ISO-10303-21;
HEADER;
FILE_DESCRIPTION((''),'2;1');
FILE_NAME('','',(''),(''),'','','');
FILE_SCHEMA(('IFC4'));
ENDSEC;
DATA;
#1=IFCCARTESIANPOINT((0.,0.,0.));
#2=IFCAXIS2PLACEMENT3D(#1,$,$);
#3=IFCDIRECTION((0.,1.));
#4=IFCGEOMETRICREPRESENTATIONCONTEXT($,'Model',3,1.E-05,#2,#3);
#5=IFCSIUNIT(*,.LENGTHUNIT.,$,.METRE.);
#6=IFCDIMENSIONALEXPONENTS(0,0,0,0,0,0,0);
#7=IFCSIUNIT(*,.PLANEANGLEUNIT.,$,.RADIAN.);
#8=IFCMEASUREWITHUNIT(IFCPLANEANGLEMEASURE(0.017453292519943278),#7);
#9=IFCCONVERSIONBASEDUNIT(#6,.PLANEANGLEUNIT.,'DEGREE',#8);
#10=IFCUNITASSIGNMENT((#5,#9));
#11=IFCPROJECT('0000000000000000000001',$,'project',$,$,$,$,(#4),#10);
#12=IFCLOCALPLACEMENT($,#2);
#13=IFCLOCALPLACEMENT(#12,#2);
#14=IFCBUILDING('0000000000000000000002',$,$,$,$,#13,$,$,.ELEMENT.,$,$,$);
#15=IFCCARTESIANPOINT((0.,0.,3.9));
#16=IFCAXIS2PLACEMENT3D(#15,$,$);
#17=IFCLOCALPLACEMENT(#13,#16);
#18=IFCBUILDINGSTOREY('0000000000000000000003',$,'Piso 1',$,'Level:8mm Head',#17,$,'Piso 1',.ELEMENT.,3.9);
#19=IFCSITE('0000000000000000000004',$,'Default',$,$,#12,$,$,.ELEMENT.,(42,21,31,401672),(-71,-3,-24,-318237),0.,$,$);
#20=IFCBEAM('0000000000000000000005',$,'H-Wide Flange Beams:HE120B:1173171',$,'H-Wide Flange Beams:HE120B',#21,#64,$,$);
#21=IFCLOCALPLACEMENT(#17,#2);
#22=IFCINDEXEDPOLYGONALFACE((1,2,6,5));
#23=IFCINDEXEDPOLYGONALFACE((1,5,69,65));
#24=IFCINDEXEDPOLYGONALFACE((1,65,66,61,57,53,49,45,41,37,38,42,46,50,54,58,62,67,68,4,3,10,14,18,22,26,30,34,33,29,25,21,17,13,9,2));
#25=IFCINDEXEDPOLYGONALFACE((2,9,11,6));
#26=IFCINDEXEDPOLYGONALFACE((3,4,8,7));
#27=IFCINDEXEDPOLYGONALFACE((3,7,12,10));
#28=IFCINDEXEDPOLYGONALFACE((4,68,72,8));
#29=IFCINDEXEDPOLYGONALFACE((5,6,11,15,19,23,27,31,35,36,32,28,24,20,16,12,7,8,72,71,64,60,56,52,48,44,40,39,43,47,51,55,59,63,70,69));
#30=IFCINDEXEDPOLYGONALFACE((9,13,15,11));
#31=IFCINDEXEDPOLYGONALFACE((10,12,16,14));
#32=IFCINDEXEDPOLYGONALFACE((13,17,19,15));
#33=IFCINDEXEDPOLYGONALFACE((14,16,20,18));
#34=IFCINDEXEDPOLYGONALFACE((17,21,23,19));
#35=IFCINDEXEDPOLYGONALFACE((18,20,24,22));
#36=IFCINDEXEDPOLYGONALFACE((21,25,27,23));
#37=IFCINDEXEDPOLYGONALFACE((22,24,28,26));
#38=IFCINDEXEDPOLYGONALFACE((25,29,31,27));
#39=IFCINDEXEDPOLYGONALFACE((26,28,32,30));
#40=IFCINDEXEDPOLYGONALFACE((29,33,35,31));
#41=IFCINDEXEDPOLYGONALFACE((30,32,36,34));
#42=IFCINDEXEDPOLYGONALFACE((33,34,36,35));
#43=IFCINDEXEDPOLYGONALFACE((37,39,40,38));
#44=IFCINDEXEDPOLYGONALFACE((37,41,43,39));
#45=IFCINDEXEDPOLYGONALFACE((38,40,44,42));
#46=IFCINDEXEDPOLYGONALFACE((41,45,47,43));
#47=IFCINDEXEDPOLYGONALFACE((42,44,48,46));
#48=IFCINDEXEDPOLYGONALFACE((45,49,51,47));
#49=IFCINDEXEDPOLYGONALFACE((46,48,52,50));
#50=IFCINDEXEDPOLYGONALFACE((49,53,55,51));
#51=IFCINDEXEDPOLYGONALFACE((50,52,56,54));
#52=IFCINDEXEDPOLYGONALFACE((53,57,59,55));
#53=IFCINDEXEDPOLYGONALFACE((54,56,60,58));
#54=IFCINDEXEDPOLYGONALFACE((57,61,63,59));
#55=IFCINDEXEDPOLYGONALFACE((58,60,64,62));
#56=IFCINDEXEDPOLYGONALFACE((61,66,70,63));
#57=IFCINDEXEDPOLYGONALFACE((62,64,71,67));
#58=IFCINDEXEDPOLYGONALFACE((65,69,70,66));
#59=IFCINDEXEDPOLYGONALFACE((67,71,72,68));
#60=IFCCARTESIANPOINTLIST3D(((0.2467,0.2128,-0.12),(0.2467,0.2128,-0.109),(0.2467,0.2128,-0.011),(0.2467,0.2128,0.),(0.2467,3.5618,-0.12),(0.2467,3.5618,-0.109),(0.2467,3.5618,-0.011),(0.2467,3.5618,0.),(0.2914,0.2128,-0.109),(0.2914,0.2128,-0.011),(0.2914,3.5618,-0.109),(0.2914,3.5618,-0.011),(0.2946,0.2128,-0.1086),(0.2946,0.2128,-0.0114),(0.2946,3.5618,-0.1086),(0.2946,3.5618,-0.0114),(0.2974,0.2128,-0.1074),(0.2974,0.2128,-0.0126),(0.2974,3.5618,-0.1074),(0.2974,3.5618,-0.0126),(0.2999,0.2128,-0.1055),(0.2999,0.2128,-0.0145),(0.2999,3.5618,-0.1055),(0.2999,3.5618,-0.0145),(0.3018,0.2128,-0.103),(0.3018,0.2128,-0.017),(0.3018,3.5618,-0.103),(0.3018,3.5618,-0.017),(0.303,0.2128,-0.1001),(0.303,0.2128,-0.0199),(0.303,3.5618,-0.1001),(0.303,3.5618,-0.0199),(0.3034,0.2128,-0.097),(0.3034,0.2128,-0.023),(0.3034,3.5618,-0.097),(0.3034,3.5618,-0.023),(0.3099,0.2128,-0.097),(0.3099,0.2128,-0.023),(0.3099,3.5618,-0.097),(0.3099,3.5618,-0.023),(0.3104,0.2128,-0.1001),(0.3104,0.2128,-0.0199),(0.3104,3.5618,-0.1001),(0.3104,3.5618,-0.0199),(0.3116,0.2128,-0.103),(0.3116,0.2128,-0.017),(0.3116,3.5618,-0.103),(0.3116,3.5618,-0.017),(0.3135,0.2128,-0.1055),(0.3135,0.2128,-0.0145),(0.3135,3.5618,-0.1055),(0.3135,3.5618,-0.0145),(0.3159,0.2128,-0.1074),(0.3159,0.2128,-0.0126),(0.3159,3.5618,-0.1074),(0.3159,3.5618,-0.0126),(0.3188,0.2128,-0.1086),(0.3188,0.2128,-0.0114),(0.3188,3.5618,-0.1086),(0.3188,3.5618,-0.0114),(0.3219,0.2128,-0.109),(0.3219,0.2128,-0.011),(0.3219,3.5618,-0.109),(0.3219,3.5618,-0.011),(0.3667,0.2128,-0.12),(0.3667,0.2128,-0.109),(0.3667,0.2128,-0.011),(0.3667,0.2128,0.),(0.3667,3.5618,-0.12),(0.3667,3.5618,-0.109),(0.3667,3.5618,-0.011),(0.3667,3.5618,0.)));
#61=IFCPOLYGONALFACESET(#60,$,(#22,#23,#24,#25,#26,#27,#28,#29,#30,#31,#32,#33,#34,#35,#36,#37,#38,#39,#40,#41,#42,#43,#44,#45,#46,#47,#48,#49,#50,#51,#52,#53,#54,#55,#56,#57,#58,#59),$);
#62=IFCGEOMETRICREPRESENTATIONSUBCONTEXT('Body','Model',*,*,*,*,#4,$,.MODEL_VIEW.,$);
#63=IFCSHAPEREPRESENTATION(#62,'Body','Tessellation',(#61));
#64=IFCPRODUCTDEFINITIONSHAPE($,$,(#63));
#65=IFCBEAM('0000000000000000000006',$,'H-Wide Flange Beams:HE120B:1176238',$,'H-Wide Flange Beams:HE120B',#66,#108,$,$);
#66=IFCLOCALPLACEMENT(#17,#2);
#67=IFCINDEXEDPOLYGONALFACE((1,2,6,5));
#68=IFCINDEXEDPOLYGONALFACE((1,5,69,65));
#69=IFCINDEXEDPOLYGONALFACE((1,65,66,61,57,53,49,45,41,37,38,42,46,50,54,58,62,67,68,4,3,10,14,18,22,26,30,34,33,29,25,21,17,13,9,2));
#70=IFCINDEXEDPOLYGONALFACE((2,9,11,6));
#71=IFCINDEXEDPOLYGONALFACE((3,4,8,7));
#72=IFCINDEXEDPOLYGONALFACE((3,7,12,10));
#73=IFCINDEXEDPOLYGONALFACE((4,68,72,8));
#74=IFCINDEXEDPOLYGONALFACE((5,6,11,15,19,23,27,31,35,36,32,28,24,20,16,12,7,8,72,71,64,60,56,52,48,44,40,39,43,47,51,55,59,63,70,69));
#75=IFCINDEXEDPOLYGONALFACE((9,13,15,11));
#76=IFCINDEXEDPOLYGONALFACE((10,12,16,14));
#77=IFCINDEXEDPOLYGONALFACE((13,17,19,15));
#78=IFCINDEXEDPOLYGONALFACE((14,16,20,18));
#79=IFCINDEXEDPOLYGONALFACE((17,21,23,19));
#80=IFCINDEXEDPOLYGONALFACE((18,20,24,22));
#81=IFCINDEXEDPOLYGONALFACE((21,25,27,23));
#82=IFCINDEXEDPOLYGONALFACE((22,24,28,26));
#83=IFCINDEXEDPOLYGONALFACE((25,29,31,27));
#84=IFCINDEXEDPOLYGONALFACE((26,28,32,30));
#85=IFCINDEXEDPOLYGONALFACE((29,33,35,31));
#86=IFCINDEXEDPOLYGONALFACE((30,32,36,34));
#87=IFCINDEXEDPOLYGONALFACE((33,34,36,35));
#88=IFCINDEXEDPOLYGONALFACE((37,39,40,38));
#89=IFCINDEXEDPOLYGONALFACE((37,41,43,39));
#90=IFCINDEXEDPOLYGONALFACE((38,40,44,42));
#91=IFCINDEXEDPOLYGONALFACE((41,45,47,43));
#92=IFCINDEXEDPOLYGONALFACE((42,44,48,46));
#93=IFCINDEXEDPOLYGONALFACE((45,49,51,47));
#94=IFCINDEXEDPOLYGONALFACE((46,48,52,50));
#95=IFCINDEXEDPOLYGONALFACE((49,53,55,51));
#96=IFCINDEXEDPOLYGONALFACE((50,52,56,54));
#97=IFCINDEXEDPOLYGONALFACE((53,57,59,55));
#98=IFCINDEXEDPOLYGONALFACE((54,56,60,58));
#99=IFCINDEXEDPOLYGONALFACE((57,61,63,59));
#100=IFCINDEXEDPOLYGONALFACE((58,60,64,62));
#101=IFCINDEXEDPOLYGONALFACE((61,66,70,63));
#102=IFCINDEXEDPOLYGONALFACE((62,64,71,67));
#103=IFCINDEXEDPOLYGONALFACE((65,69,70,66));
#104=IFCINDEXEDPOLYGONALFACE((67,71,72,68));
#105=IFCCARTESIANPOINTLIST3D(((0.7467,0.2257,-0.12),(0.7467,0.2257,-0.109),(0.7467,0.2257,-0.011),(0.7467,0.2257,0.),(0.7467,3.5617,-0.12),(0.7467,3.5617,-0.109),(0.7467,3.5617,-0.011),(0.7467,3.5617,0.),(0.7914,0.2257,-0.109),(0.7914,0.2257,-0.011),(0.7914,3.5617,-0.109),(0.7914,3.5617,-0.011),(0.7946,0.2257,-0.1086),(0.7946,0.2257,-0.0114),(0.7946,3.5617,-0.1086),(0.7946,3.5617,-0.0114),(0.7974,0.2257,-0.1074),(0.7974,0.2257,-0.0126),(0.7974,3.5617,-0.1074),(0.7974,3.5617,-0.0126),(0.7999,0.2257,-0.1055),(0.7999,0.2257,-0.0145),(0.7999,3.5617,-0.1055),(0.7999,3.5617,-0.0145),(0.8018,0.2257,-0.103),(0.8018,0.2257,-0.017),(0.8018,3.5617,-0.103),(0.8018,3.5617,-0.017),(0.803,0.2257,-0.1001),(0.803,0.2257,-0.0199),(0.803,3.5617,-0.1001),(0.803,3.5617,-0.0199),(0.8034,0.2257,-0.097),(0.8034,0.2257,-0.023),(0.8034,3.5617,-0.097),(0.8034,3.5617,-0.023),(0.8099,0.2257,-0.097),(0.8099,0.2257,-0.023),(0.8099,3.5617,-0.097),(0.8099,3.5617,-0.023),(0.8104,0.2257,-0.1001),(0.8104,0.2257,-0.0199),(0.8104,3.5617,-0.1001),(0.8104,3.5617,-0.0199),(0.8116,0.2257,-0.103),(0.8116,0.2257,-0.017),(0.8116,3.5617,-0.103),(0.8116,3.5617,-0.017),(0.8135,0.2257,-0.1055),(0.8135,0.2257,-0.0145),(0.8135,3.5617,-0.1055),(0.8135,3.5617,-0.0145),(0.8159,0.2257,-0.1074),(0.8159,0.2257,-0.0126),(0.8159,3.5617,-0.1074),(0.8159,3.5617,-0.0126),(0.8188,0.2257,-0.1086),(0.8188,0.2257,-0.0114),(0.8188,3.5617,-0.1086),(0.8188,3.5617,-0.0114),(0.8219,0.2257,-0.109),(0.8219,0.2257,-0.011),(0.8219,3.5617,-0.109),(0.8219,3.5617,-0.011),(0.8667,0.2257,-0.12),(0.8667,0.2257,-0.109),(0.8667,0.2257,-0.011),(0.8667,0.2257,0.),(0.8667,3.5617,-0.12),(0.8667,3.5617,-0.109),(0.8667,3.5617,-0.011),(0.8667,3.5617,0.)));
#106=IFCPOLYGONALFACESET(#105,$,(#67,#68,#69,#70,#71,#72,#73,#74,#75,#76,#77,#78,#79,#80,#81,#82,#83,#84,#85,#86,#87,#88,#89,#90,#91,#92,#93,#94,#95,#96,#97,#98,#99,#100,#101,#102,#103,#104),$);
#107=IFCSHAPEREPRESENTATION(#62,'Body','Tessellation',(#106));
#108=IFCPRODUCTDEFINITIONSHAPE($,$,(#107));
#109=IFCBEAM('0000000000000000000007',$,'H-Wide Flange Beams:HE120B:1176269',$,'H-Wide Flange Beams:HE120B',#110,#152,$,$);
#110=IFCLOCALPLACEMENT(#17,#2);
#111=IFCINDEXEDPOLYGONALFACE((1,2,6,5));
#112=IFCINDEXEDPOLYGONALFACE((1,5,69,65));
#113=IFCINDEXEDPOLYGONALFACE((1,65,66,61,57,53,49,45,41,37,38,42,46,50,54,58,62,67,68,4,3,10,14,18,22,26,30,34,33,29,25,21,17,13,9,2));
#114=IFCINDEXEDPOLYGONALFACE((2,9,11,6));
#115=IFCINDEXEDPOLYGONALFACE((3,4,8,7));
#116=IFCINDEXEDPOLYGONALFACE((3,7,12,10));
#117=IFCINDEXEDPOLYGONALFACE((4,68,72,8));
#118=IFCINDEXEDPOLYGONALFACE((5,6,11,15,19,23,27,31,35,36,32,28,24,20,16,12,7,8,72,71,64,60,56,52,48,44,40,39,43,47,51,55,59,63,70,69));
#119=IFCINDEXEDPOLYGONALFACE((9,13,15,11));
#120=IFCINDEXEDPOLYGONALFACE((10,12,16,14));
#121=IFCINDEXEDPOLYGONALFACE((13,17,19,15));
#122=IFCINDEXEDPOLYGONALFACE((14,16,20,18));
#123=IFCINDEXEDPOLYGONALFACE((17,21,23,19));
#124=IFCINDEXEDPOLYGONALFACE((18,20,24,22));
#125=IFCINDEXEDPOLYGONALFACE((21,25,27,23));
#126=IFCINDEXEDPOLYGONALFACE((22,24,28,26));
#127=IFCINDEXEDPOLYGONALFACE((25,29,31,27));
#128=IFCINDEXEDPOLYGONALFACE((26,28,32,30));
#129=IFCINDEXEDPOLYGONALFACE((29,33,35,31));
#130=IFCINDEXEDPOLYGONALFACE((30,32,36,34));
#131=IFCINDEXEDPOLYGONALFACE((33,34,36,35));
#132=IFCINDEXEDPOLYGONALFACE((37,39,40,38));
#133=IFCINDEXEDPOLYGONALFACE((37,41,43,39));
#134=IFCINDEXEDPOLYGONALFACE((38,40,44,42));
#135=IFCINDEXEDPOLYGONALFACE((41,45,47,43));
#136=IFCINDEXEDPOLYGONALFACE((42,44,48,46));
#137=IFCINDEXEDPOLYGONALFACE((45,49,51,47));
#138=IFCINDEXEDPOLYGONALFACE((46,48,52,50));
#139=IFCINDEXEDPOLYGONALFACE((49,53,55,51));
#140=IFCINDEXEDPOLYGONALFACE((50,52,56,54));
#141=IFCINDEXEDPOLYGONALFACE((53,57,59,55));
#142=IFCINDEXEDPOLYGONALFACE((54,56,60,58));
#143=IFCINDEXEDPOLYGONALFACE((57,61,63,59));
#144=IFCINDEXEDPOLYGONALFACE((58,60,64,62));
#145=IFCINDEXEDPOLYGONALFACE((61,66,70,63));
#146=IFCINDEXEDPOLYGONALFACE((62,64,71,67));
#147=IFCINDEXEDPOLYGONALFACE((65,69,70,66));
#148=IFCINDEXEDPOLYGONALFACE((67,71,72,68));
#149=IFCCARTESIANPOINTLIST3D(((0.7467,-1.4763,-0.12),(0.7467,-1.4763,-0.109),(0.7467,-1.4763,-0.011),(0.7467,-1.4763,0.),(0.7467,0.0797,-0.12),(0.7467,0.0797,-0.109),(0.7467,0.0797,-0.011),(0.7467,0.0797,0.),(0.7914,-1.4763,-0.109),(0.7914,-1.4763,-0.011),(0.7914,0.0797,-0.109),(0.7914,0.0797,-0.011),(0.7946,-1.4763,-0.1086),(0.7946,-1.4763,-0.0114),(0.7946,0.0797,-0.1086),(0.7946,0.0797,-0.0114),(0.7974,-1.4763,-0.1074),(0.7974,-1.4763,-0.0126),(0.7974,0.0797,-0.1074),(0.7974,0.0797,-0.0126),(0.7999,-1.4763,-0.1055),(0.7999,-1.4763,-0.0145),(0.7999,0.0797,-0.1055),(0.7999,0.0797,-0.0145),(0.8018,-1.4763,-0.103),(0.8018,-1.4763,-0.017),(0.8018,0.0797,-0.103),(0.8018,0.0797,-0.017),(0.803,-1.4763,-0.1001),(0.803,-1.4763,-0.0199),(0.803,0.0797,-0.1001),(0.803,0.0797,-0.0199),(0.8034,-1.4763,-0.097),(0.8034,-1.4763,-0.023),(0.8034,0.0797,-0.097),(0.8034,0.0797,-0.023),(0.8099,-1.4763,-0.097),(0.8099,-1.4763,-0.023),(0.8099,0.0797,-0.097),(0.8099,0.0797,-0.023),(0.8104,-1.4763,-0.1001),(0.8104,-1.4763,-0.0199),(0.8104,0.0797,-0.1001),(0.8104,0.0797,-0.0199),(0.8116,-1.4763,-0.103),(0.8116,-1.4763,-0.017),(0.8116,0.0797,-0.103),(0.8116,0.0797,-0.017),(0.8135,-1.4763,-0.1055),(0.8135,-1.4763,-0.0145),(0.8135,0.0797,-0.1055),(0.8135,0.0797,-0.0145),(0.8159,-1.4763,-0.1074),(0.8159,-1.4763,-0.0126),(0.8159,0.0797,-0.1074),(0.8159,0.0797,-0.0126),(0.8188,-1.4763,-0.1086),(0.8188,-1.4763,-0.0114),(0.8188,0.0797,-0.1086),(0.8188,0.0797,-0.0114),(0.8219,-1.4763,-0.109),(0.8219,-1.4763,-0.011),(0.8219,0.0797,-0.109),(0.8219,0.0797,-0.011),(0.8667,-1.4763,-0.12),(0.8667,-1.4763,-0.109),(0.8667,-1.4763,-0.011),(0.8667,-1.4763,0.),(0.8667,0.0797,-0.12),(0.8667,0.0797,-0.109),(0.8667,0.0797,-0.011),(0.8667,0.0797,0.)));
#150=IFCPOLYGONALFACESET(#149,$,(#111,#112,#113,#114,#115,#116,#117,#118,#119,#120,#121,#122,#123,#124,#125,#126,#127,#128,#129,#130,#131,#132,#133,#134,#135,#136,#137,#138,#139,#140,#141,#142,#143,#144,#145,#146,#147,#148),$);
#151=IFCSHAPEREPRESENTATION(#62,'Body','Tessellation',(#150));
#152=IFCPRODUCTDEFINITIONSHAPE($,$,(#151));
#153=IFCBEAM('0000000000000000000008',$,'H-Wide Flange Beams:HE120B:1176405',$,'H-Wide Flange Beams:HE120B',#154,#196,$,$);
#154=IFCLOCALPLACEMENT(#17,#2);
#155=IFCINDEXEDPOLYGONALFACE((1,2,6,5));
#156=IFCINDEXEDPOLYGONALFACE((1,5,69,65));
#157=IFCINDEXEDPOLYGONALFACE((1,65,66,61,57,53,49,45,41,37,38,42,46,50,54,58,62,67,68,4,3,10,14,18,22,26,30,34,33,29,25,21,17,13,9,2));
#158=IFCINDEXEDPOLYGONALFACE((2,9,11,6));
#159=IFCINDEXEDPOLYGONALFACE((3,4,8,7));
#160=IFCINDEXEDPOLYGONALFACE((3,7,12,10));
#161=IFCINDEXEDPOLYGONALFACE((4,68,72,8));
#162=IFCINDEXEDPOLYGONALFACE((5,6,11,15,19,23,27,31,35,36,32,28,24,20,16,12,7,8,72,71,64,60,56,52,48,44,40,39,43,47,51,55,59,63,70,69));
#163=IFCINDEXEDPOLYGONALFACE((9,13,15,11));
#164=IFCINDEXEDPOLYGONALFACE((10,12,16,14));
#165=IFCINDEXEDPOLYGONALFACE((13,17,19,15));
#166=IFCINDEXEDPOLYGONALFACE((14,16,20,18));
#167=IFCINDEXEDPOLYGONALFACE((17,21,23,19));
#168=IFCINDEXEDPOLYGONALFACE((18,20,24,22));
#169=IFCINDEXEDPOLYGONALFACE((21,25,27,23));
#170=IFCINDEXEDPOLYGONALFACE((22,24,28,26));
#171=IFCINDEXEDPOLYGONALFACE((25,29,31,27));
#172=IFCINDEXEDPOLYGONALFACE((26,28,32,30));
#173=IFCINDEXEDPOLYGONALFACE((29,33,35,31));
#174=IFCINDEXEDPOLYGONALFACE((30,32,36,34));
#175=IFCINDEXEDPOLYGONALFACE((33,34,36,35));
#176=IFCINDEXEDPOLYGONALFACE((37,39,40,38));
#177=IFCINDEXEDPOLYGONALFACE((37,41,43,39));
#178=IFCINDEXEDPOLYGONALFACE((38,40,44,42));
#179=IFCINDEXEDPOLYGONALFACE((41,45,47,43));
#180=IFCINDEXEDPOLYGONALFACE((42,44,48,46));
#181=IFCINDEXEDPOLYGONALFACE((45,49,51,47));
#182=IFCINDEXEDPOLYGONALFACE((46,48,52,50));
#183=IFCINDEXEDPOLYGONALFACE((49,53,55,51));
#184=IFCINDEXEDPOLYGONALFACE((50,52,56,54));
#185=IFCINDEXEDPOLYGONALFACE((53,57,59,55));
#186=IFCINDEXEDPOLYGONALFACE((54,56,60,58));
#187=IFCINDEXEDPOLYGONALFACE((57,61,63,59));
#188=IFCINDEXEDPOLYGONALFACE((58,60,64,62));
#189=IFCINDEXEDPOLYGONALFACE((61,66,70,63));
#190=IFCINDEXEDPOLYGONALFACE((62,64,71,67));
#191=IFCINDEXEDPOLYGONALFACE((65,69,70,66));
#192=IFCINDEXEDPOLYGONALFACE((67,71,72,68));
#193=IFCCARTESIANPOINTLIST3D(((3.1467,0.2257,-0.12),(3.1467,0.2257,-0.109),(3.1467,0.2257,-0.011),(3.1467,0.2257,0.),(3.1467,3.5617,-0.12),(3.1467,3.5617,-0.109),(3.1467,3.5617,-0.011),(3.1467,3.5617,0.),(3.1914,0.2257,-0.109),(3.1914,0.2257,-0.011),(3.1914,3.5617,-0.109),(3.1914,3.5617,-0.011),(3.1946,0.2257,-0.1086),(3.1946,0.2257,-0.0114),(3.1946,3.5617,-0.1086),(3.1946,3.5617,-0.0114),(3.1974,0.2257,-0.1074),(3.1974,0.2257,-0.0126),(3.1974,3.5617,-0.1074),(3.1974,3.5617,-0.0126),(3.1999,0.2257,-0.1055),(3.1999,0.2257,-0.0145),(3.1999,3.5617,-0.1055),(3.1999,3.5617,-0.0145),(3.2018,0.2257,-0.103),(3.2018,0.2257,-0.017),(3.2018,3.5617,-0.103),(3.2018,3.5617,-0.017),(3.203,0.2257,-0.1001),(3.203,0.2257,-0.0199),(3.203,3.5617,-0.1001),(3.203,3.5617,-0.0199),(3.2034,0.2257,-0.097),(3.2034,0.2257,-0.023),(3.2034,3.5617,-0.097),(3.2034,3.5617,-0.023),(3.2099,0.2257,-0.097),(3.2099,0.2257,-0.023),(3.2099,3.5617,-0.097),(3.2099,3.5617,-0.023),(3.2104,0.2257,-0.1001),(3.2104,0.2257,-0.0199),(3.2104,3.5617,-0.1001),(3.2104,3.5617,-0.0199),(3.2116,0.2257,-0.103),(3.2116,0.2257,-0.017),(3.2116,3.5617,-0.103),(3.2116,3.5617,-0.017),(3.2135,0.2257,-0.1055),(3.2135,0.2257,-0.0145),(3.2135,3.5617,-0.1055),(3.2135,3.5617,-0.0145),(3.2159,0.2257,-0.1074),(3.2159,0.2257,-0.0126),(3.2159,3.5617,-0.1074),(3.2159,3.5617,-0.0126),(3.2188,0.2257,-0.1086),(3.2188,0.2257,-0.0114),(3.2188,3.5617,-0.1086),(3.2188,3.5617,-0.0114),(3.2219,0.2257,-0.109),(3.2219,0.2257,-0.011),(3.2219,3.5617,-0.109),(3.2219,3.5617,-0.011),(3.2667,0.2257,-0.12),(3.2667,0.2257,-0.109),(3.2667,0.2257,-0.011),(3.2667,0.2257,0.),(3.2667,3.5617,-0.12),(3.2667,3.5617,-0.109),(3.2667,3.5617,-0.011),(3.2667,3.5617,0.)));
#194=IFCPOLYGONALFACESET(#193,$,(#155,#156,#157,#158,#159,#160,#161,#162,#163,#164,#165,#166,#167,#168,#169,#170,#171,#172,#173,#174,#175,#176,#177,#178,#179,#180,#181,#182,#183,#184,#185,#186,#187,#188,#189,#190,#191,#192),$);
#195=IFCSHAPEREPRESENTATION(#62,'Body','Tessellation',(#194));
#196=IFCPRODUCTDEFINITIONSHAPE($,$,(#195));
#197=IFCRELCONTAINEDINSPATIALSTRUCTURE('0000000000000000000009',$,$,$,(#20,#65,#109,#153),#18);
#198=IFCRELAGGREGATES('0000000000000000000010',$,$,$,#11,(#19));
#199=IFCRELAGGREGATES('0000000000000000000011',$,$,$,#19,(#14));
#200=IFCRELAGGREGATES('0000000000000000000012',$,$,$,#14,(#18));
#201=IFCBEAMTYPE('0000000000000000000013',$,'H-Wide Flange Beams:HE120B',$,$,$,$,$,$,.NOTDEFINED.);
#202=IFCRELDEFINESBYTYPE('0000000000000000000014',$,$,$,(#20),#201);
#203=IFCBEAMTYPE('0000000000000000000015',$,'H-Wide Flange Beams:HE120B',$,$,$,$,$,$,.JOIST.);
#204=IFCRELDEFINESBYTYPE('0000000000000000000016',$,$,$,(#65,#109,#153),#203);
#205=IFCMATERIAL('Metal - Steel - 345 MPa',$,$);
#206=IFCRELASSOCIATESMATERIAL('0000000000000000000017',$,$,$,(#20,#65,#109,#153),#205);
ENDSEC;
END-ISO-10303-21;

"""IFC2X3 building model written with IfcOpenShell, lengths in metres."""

from ifc_helpers import new_model, entity, si_unit, converted_unit, direction, frame, frame_2d, origin, place, context, subcontext, project, spatial, i_section, extrude, material, type_object, element, save


model = new_model("IFC2X3")

# Units and contexts
model_context = context("Model", 3, precision=1e-05, world=origin(), true_north=direction((0.0, 1.0)))
body_context = subcontext(model_context, "Body", "Model", "MODEL_VIEW")
ifc_project = project(units=[si_unit("LENGTHUNIT", "METRE"), converted_unit("PLANEANGLEUNIT", "DEGREE", entity("IfcPlaneAngleMeasure", 0.017453292519943278), si_unit("PLANEANGLEUNIT", "RADIAN"), dimensions=[0, 0, 0, 0, 0, 0, 0])], contexts=[model_context])

# Site, building, storey
site_placement = place(None, origin())
site = spatial("IfcSite", under=ifc_project, at=site_placement, Name="Default", CompositionType="ELEMENT", RefLatitude=(42, 21, 31, 401672), RefLongitude=(-71, -3, -24, -318237), RefElevation=0.0)
building_placement = place(site_placement, origin())
building = spatial("IfcBuilding", under=site, at=building_placement, CompositionType="ELEMENT")
storey_placement = place(building_placement, frame((0.0, 0.0, 3.9)))
storey = spatial("IfcBuildingStorey", under=building, at=storey_placement, Name="Piso 1", ObjectType="Level:8mm Head", LongName="Piso 1", CompositionType="ELEMENT", Elevation=3.9)

# Beams
ifc_material_1 = material(Name="Metal - Steel - 345 MPa")
beam_type_1 = type_object("IfcBeamType", Name="H-Wide Flange Beams:HE120B", PredefinedType="NOTDEFINED")
beam_1_placement = place(storey_placement, frame((0.3067, 0.1508, 0.0), z_axis=(0.0, 0.0, 1.0), x_axis=(0.0, 1.0, 0.0)))
element("IfcBeam", 1, at=beam_1_placement, inside=storey, type_object=beam_type_1, material=ifc_material_1, Name="H-Wide Flange Beams:HE120B:1173171", ObjectType="H-Wide Flange Beams:HE120B", context=body_context, shape_type="SweptSolid", body=[
    extrude(i_section(OverallWidth=0.12, OverallDepth=0.12, WebThickness=0.0065, FlangeThickness=0.011, FilletRadius=0.012, at=frame_2d((0.0, 0.0), x_axis=(0.0, 1.0))), frame((0.062, 0.0, -0.06), z_axis=(1.0, 0.0, 0.0), x_axis=(0.0, 0.0, -1.0)), (0.0, 0.0, 1.0), 3.349),
])
beam_type_2 = type_object("IfcBeamType", Name="H-Wide Flange Beams:HE120B", PredefinedType="JOIST")
beam_2_placement = place(storey_placement, frame((0.8067, 3.6349, 0.0), z_axis=(0.0, 0.0, 1.0), x_axis=(0.0, -1.0, 0.0)))
element("IfcBeam", 2, at=beam_2_placement, inside=storey, type_object=beam_type_2, material=ifc_material_1, Name="H-Wide Flange Beams:HE120B:1176238", ObjectType="H-Wide Flange Beams:HE120B", context=body_context, shape_type="SweptSolid", body=[
    extrude(i_section(OverallWidth=0.12, OverallDepth=0.12, WebThickness=0.0065, FlangeThickness=0.011, FilletRadius=0.012, at=frame_2d((0.0, 0.0), x_axis=(0.0, 1.0))), frame((0.0732, 0.0, -0.06), z_axis=(1.0, 0.0, 0.0), x_axis=(0.0, 0.0, -1.0)), (0.0, 0.0, 1.0), 3.336),
])
beam_3_placement = place(storey_placement, frame((0.8067, 0.1526, 0.0), z_axis=(0.0, 0.0, 1.0), x_axis=(0.0, -1.0, 0.0)))
element("IfcBeam", 3, at=beam_3_placement, inside=storey, type_object=beam_type_2, material=ifc_material_1, Name="H-Wide Flange Beams:HE120B:1176269", ObjectType="H-Wide Flange Beams:HE120B", context=body_context, shape_type="SweptSolid", body=[
    extrude(i_section(OverallWidth=0.12, OverallDepth=0.12, WebThickness=0.0065, FlangeThickness=0.011, FilletRadius=0.012, at=frame_2d((0.0, 0.0), x_axis=(0.0, 1.0))), frame((0.0729, 0.0, -0.06), z_axis=(1.0, 0.0, 0.0), x_axis=(0.0, 0.0, -1.0)), (0.0, 0.0, 1.0), 1.556),
])
beam_4_placement = place(storey_placement, frame((3.2067, 3.6349, 0.0), z_axis=(0.0, 0.0, 1.0), x_axis=(0.0, -1.0, 0.0)))
element("IfcBeam", 4, at=beam_4_placement, inside=storey, type_object=beam_type_2, material=ifc_material_1, Name="H-Wide Flange Beams:HE120B:1176405", ObjectType="H-Wide Flange Beams:HE120B", context=body_context, shape_type="SweptSolid", body=[
    extrude(i_section(OverallWidth=0.12, OverallDepth=0.12, WebThickness=0.0065, FlangeThickness=0.011, FilletRadius=0.012, at=frame_2d((0.0, 0.0), x_axis=(0.0, 1.0))), frame((0.0732, 0.0, -0.06), z_axis=(1.0, 0.0, 0.0), x_axis=(0.0, 0.0, -1.0)), (0.0, 0.0, 1.0), 3.336),
])

save(model, "model.ifc")
